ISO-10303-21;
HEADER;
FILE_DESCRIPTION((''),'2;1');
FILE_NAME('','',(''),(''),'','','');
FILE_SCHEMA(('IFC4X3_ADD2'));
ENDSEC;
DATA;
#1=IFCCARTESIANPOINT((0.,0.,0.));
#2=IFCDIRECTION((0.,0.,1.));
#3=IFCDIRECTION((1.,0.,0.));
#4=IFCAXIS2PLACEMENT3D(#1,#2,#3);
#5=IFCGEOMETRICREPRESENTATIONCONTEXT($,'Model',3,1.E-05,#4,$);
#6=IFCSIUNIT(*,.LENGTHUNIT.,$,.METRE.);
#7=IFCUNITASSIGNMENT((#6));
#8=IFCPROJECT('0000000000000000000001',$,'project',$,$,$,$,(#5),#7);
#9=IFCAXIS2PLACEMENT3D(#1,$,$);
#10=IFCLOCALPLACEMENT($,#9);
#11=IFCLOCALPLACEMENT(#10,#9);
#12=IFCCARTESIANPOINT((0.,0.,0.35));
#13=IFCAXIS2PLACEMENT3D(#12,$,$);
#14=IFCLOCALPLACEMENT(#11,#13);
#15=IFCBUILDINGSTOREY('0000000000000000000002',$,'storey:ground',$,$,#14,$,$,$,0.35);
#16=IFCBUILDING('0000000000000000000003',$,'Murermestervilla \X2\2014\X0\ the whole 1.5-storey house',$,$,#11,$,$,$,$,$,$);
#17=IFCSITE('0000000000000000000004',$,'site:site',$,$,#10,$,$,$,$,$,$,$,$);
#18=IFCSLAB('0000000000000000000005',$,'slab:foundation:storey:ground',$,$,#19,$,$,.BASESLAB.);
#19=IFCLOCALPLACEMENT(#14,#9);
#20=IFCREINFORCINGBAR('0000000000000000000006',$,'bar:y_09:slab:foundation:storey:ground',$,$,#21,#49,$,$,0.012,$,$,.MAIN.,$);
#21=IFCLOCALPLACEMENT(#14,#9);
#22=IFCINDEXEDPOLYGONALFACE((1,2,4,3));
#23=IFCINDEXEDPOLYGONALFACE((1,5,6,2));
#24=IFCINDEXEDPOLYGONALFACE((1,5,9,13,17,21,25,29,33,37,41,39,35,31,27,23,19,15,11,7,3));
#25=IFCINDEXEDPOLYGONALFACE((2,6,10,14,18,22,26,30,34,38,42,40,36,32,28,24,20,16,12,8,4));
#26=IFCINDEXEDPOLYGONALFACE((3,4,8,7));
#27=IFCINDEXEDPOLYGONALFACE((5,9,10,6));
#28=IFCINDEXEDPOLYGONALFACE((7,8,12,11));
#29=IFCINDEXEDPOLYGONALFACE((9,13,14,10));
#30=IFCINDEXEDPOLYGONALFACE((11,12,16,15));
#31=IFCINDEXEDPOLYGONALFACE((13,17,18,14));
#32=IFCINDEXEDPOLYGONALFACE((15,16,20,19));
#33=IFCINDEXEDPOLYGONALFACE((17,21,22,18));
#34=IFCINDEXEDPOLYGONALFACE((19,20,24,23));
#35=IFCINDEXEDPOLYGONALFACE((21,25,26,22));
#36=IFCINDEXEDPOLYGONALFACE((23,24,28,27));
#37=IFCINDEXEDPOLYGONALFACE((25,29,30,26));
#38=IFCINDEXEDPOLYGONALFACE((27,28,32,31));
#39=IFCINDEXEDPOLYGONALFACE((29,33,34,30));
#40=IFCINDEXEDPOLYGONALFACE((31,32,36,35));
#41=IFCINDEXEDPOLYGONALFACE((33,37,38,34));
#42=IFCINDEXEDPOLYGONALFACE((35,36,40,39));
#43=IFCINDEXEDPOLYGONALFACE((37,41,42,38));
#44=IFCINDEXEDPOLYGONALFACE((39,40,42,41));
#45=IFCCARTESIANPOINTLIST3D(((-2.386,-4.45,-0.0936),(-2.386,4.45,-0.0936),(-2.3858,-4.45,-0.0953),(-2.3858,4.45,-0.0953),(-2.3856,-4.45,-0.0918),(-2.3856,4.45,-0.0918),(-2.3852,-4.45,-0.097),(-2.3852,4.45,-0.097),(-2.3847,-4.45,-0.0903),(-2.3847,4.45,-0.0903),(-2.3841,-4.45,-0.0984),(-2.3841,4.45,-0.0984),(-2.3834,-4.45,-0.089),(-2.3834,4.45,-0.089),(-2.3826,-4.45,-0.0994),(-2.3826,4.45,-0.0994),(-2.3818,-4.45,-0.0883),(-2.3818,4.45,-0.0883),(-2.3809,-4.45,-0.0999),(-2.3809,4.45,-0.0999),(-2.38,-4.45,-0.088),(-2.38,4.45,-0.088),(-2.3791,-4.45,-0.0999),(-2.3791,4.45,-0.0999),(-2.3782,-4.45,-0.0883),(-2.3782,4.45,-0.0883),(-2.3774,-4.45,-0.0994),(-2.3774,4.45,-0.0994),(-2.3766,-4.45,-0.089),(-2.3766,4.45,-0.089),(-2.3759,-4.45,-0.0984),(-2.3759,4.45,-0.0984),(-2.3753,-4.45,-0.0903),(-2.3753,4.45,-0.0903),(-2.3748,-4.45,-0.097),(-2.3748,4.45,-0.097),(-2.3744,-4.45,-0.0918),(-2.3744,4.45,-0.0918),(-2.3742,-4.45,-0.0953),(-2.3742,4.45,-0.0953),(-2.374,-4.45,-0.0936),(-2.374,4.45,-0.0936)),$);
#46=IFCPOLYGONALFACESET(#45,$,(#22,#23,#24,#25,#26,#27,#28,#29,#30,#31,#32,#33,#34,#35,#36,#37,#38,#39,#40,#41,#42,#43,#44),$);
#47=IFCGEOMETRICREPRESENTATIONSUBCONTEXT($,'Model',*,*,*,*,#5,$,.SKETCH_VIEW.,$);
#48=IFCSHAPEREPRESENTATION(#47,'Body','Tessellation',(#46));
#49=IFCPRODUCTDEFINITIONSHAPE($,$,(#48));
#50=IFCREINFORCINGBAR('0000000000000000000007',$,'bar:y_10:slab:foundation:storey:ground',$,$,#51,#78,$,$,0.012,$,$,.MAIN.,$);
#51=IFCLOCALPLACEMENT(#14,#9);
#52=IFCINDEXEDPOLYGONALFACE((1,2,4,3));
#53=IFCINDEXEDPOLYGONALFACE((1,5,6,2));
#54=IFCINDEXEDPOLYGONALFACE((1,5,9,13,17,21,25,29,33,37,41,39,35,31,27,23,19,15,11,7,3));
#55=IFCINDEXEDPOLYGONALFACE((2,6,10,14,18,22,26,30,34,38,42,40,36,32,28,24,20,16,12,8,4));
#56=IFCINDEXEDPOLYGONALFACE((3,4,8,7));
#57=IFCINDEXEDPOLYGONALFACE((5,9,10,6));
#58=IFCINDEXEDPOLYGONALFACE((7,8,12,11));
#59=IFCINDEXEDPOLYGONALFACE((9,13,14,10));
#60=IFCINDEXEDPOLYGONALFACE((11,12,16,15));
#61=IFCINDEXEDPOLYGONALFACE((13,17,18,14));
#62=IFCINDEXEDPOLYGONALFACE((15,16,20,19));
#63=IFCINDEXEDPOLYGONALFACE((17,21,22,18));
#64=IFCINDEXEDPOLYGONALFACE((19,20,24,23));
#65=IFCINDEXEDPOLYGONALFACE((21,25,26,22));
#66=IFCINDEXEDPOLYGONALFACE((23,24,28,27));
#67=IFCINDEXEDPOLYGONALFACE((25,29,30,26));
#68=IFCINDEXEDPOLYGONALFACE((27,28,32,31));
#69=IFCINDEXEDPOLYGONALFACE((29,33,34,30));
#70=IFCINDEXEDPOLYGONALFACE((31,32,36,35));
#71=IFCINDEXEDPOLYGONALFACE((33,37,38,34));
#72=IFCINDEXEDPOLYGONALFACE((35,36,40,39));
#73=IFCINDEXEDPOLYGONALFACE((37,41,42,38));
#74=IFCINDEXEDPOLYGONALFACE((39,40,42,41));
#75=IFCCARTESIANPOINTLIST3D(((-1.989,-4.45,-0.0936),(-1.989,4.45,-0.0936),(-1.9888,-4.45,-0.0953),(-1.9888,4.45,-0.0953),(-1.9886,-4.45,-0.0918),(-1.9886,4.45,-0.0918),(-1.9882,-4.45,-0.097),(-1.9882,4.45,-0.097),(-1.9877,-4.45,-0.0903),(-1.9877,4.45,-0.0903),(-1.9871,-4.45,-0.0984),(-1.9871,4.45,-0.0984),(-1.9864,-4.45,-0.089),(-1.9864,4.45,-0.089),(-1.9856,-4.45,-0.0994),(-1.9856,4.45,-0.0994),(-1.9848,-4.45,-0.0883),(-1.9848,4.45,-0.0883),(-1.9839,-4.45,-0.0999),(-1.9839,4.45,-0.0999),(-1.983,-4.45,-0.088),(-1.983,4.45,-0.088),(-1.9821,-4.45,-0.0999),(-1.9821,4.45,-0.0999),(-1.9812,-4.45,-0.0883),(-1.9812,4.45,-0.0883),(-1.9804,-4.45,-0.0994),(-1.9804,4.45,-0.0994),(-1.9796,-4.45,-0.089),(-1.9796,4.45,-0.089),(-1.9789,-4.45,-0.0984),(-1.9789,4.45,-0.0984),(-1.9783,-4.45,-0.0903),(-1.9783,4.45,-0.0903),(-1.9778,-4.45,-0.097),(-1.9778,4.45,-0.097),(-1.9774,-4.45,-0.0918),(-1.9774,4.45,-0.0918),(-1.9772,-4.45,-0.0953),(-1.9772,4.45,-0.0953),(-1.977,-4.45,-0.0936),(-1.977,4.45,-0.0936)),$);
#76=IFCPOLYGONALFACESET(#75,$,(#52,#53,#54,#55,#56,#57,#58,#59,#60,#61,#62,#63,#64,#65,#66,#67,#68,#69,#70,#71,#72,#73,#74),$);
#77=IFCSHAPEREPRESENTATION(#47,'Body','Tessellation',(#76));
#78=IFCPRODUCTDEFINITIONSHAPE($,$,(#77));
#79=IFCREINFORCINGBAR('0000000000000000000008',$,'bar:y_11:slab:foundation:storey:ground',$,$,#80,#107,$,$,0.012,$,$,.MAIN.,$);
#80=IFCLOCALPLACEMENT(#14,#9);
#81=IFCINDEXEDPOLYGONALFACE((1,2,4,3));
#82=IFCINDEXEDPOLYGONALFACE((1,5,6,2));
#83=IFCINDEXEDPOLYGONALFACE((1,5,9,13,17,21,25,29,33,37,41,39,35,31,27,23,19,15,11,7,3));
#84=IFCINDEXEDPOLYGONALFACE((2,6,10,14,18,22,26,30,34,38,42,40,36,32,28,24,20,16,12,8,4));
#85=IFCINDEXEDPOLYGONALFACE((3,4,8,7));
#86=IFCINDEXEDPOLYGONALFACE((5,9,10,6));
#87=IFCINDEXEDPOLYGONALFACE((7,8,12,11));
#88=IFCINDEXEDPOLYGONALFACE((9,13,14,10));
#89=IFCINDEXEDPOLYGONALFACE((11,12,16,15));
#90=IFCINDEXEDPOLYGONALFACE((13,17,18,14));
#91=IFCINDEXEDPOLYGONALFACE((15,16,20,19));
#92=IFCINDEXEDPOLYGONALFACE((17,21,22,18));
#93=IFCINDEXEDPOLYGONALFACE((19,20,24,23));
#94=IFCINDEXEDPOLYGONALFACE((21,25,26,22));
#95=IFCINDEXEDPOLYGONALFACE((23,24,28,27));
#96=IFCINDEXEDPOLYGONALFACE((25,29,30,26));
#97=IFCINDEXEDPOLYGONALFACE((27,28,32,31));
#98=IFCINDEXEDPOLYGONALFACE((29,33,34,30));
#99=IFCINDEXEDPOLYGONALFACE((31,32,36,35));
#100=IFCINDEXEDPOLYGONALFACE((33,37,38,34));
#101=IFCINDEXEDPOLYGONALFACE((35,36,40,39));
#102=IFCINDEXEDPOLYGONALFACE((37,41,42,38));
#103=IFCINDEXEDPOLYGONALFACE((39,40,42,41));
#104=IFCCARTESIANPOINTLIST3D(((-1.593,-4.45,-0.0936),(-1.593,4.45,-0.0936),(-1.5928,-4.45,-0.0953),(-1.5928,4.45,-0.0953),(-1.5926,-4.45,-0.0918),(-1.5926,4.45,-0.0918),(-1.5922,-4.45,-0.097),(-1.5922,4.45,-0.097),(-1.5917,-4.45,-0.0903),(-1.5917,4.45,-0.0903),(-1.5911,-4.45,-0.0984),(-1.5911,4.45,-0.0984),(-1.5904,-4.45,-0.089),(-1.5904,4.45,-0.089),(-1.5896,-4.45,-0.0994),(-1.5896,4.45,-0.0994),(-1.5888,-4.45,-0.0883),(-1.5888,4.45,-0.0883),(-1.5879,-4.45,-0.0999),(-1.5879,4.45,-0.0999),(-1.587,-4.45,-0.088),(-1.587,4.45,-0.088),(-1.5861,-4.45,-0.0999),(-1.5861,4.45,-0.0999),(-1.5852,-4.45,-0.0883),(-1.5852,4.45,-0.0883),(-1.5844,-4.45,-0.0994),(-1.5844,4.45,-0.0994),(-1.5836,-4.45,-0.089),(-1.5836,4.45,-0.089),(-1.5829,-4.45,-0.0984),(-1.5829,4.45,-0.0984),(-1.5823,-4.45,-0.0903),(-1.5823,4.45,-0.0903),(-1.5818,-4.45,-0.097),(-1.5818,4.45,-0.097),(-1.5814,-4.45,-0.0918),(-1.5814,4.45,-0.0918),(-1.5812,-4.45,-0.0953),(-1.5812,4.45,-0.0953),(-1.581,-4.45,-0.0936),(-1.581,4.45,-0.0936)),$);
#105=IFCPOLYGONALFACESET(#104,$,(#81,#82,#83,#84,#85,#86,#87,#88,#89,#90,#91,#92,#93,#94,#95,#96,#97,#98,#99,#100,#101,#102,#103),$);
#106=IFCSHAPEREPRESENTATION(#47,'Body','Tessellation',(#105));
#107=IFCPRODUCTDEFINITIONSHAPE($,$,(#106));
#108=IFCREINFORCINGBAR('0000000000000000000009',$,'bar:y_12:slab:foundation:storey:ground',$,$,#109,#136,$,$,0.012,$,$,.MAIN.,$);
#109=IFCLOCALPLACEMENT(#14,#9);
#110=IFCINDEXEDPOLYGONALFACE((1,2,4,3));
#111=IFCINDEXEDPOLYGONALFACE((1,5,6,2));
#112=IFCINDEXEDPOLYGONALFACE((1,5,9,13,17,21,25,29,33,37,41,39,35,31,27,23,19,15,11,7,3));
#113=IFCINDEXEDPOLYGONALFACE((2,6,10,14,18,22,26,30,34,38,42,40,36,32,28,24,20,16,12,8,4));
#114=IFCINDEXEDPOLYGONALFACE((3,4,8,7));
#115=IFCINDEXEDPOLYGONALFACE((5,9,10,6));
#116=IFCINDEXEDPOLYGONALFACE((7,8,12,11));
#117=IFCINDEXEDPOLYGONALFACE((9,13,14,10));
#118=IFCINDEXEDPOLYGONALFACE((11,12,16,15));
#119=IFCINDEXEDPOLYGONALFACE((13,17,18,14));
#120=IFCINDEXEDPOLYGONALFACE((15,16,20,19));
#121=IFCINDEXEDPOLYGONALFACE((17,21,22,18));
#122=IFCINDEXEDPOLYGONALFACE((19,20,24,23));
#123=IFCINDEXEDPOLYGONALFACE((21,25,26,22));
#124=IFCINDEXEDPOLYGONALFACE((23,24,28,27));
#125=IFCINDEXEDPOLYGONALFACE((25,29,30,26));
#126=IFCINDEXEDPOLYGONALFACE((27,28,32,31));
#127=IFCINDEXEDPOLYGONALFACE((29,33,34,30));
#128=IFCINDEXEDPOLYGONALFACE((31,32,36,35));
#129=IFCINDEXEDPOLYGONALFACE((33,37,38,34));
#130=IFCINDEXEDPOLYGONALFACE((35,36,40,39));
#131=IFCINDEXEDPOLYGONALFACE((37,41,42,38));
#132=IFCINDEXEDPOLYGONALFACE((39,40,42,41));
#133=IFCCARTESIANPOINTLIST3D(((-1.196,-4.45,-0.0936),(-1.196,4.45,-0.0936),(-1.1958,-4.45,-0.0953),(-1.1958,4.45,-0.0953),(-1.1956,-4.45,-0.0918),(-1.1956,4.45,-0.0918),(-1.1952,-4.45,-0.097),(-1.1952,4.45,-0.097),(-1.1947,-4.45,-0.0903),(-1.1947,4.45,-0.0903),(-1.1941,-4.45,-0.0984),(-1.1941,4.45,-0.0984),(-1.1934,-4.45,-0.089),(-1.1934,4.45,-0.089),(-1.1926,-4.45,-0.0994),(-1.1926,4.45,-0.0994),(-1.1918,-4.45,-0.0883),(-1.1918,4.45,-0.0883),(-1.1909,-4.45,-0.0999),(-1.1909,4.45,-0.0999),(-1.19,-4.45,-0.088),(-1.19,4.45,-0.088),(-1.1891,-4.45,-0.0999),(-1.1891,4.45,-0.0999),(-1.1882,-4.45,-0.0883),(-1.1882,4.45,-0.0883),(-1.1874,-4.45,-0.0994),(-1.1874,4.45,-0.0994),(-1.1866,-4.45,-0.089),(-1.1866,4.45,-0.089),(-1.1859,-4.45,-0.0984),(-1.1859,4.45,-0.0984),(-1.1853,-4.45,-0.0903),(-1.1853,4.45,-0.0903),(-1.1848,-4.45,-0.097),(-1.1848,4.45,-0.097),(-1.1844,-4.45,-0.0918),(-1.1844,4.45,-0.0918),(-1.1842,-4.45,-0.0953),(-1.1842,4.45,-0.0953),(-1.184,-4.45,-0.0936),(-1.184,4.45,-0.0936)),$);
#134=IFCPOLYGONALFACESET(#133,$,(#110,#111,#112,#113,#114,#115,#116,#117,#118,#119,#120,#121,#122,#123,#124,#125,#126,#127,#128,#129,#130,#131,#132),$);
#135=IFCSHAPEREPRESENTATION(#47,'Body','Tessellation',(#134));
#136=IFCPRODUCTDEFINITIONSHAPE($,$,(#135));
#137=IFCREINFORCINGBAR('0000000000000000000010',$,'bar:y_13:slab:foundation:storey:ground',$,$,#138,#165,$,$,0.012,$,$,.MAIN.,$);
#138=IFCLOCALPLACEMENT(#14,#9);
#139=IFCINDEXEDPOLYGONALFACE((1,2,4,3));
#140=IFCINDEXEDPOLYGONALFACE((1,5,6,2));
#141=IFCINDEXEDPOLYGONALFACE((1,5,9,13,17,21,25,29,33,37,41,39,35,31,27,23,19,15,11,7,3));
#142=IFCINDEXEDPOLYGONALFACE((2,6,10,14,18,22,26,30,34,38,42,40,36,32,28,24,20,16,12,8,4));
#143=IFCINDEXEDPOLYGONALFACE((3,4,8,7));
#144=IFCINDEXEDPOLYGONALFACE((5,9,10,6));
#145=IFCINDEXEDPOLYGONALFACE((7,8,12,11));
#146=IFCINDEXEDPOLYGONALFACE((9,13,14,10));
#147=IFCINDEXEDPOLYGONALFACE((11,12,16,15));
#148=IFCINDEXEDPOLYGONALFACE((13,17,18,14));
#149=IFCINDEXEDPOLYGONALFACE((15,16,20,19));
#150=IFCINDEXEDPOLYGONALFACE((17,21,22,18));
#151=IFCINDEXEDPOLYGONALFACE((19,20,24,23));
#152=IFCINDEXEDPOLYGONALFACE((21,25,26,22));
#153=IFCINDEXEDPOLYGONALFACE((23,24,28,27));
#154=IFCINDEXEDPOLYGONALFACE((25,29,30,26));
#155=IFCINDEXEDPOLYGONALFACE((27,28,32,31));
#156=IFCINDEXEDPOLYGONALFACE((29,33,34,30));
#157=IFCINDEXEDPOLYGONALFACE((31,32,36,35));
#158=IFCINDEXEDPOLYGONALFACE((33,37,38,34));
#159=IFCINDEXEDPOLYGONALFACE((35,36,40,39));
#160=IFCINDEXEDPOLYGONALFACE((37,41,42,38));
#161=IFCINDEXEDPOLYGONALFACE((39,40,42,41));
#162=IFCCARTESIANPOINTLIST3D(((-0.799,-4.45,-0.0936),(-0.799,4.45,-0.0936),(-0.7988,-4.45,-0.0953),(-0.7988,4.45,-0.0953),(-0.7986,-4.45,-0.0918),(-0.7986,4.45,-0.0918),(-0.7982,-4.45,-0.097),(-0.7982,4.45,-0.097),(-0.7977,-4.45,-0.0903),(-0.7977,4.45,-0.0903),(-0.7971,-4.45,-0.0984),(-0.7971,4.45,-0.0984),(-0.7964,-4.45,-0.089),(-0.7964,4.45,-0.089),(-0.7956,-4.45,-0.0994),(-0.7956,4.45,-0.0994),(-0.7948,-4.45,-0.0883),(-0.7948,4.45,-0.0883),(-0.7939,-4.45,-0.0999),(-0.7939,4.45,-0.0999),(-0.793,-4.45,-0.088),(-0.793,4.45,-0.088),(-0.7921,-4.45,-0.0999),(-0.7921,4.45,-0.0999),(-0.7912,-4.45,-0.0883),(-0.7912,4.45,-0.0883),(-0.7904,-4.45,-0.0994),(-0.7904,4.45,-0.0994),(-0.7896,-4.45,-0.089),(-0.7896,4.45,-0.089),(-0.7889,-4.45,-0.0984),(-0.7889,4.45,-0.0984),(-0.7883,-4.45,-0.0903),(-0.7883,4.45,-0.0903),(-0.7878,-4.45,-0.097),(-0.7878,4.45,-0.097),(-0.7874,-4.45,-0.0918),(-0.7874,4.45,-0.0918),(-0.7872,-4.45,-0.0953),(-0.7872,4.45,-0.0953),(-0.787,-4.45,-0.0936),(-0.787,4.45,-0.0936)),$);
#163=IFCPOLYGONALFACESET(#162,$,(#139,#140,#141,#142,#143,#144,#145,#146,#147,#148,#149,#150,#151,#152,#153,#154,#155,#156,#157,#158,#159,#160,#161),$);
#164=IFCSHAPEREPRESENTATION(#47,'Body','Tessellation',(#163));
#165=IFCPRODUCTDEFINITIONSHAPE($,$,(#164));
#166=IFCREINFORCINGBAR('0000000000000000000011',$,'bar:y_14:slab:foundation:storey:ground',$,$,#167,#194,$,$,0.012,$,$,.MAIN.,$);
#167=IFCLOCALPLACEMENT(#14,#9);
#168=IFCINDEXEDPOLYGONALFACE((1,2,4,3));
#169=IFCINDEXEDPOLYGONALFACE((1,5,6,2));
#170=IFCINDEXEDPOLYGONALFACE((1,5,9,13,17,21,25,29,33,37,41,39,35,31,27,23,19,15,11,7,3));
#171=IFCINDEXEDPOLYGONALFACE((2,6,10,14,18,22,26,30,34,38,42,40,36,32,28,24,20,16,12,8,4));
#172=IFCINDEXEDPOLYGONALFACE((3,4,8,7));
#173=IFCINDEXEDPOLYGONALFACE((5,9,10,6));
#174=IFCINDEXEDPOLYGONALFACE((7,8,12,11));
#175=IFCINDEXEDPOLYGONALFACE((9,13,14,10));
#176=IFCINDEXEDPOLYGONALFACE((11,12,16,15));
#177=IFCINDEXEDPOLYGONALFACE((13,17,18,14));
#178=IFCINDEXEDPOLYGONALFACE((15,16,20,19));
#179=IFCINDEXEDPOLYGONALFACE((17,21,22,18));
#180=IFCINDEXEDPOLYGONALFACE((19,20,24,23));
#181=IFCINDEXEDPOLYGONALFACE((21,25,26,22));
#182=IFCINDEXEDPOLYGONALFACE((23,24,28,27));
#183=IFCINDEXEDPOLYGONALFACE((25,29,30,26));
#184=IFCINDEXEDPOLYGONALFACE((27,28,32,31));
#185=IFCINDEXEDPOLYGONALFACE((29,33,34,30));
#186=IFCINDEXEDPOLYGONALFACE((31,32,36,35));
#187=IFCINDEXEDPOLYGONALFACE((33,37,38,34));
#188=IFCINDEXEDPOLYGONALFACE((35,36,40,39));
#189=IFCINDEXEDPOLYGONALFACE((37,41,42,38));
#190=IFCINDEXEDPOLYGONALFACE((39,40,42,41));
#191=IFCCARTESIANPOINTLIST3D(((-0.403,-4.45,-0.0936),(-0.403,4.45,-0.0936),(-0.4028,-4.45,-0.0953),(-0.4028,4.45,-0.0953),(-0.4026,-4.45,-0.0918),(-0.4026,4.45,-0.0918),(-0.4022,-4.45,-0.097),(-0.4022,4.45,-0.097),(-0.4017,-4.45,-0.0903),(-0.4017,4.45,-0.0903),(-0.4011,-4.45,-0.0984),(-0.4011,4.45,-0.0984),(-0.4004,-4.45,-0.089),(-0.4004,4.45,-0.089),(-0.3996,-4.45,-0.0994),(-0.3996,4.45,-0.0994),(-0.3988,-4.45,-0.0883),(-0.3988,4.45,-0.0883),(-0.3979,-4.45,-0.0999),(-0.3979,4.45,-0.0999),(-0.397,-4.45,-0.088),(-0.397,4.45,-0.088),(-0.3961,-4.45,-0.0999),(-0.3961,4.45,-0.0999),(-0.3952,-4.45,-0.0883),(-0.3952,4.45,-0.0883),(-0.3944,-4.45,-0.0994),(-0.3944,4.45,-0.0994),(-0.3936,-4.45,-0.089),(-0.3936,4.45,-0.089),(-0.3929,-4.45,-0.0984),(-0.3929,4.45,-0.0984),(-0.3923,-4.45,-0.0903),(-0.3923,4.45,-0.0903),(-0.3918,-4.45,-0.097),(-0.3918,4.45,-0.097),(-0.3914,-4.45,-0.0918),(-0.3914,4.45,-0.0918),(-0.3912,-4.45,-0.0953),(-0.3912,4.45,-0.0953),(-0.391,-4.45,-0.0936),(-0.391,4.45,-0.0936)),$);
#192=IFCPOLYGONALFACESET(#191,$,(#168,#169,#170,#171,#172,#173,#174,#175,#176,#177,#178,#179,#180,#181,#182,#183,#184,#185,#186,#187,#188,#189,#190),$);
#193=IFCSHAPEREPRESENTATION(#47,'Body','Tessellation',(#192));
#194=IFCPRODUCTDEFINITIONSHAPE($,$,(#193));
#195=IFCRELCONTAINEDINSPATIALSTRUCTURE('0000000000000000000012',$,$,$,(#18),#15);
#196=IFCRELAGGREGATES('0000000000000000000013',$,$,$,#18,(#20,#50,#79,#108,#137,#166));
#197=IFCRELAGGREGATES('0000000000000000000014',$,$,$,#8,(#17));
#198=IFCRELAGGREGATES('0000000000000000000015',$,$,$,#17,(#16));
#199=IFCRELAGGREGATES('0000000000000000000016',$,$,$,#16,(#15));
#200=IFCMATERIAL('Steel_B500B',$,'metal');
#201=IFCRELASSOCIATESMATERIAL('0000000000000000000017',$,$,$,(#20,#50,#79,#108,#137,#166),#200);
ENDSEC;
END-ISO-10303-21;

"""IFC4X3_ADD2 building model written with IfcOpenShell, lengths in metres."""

from ifc_helpers import new_model, entity, si_unit, frame, origin, origin_with_axes, place, context, subcontext, project, spatial, material, element, aggregate, save


model = new_model("IFC4X3_ADD2")

# Units and contexts
model_context = context("Model", 3, precision=1e-05, world=origin_with_axes())
sub_context = subcontext(model_context, None, "Model", "SKETCH_VIEW")
ifc_project = project(units=[si_unit("LENGTHUNIT", "METRE")], contexts=[model_context])

# Site, building, storey
placement = place(None, origin())
site = spatial("IfcSite", under=ifc_project, at=placement, Name="site:site")
building_placement = place(placement, origin())
building = spatial("IfcBuilding", under=site, at=building_placement, Name="Murermestervilla — the whole 1.5-storey house")
storey_placement = place(building_placement, frame((0.0, 0.0, 0.35)))
storey = spatial("IfcBuildingStorey", under=building, at=storey_placement, Name="storey:ground", Elevation=0.35)

# Slab, reinforcing bars
slab_placement = place(storey_placement, frame((0.0, 0.0, -0.35)))
slab = element("IfcSlab", 1, at=slab_placement, inside=storey, Name="slab:foundation:storey:ground", PredefinedType="BASESLAB")
ifc_material = material(Name="Steel_B500B", Category="metal")
reinforcing_bar_1 = element("IfcReinforcingBar", 2, at=placement, material=ifc_material, Name="bar:y_09:slab:foundation:storey:ground", NominalDiameter=0.012, PredefinedType="MAIN", context=sub_context, shape_type="AdvancedSweptSolid", body=[
    entity("IfcSweptDiskSolid", entity("IfcPolyline", [entity("IfcCartesianPoint", [-2.38, -4.45, 0.256]), entity("IfcCartesianPoint", [-2.38, 4.45, 0.256])]), 0.006),
])
reinforcing_bar_2 = element("IfcReinforcingBar", 3, at=placement, material=ifc_material, Name="bar:y_10:slab:foundation:storey:ground", NominalDiameter=0.012, PredefinedType="MAIN", context=sub_context, shape_type="AdvancedSweptSolid", body=[
    entity("IfcSweptDiskSolid", entity("IfcPolyline", [entity("IfcCartesianPoint", [-1.983, -4.45, 0.256]), entity("IfcCartesianPoint", [-1.983, 4.45, 0.256])]), 0.006),
])
reinforcing_bar_3 = element("IfcReinforcingBar", 4, at=placement, material=ifc_material, Name="bar:y_11:slab:foundation:storey:ground", NominalDiameter=0.012, PredefinedType="MAIN", context=sub_context, shape_type="AdvancedSweptSolid", body=[
    entity("IfcSweptDiskSolid", entity("IfcPolyline", [entity("IfcCartesianPoint", [-1.587, -4.45, 0.256]), entity("IfcCartesianPoint", [-1.587, 4.45, 0.256])]), 0.006),
])
reinforcing_bar_4 = element("IfcReinforcingBar", 5, at=placement, material=ifc_material, Name="bar:y_12:slab:foundation:storey:ground", NominalDiameter=0.012, PredefinedType="MAIN", context=sub_context, shape_type="AdvancedSweptSolid", body=[
    entity("IfcSweptDiskSolid", entity("IfcPolyline", [entity("IfcCartesianPoint", [-1.19, -4.45, 0.256]), entity("IfcCartesianPoint", [-1.19, 4.45, 0.256])]), 0.006),
])
reinforcing_bar_5 = element("IfcReinforcingBar", 6, at=placement, material=ifc_material, Name="bar:y_13:slab:foundation:storey:ground", NominalDiameter=0.012, PredefinedType="MAIN", context=sub_context, shape_type="AdvancedSweptSolid", body=[
    entity("IfcSweptDiskSolid", entity("IfcPolyline", [entity("IfcCartesianPoint", [-0.793, -4.45, 0.256]), entity("IfcCartesianPoint", [-0.793, 4.45, 0.256])]), 0.006),
])
reinforcing_bar_6 = element("IfcReinforcingBar", 7, at=placement, material=ifc_material, Name="bar:y_14:slab:foundation:storey:ground", NominalDiameter=0.012, PredefinedType="MAIN", context=sub_context, shape_type="AdvancedSweptSolid", body=[
    entity("IfcSweptDiskSolid", entity("IfcPolyline", [entity("IfcCartesianPoint", [-0.397, -4.45, 0.256]), entity("IfcCartesianPoint", [-0.397, 4.45, 0.256])]), 0.006),
])
aggregate(slab, [reinforcing_bar_1, reinforcing_bar_2, reinforcing_bar_3, reinforcing_bar_4, reinforcing_bar_5, reinforcing_bar_6])

save(model, "model.ifc")
